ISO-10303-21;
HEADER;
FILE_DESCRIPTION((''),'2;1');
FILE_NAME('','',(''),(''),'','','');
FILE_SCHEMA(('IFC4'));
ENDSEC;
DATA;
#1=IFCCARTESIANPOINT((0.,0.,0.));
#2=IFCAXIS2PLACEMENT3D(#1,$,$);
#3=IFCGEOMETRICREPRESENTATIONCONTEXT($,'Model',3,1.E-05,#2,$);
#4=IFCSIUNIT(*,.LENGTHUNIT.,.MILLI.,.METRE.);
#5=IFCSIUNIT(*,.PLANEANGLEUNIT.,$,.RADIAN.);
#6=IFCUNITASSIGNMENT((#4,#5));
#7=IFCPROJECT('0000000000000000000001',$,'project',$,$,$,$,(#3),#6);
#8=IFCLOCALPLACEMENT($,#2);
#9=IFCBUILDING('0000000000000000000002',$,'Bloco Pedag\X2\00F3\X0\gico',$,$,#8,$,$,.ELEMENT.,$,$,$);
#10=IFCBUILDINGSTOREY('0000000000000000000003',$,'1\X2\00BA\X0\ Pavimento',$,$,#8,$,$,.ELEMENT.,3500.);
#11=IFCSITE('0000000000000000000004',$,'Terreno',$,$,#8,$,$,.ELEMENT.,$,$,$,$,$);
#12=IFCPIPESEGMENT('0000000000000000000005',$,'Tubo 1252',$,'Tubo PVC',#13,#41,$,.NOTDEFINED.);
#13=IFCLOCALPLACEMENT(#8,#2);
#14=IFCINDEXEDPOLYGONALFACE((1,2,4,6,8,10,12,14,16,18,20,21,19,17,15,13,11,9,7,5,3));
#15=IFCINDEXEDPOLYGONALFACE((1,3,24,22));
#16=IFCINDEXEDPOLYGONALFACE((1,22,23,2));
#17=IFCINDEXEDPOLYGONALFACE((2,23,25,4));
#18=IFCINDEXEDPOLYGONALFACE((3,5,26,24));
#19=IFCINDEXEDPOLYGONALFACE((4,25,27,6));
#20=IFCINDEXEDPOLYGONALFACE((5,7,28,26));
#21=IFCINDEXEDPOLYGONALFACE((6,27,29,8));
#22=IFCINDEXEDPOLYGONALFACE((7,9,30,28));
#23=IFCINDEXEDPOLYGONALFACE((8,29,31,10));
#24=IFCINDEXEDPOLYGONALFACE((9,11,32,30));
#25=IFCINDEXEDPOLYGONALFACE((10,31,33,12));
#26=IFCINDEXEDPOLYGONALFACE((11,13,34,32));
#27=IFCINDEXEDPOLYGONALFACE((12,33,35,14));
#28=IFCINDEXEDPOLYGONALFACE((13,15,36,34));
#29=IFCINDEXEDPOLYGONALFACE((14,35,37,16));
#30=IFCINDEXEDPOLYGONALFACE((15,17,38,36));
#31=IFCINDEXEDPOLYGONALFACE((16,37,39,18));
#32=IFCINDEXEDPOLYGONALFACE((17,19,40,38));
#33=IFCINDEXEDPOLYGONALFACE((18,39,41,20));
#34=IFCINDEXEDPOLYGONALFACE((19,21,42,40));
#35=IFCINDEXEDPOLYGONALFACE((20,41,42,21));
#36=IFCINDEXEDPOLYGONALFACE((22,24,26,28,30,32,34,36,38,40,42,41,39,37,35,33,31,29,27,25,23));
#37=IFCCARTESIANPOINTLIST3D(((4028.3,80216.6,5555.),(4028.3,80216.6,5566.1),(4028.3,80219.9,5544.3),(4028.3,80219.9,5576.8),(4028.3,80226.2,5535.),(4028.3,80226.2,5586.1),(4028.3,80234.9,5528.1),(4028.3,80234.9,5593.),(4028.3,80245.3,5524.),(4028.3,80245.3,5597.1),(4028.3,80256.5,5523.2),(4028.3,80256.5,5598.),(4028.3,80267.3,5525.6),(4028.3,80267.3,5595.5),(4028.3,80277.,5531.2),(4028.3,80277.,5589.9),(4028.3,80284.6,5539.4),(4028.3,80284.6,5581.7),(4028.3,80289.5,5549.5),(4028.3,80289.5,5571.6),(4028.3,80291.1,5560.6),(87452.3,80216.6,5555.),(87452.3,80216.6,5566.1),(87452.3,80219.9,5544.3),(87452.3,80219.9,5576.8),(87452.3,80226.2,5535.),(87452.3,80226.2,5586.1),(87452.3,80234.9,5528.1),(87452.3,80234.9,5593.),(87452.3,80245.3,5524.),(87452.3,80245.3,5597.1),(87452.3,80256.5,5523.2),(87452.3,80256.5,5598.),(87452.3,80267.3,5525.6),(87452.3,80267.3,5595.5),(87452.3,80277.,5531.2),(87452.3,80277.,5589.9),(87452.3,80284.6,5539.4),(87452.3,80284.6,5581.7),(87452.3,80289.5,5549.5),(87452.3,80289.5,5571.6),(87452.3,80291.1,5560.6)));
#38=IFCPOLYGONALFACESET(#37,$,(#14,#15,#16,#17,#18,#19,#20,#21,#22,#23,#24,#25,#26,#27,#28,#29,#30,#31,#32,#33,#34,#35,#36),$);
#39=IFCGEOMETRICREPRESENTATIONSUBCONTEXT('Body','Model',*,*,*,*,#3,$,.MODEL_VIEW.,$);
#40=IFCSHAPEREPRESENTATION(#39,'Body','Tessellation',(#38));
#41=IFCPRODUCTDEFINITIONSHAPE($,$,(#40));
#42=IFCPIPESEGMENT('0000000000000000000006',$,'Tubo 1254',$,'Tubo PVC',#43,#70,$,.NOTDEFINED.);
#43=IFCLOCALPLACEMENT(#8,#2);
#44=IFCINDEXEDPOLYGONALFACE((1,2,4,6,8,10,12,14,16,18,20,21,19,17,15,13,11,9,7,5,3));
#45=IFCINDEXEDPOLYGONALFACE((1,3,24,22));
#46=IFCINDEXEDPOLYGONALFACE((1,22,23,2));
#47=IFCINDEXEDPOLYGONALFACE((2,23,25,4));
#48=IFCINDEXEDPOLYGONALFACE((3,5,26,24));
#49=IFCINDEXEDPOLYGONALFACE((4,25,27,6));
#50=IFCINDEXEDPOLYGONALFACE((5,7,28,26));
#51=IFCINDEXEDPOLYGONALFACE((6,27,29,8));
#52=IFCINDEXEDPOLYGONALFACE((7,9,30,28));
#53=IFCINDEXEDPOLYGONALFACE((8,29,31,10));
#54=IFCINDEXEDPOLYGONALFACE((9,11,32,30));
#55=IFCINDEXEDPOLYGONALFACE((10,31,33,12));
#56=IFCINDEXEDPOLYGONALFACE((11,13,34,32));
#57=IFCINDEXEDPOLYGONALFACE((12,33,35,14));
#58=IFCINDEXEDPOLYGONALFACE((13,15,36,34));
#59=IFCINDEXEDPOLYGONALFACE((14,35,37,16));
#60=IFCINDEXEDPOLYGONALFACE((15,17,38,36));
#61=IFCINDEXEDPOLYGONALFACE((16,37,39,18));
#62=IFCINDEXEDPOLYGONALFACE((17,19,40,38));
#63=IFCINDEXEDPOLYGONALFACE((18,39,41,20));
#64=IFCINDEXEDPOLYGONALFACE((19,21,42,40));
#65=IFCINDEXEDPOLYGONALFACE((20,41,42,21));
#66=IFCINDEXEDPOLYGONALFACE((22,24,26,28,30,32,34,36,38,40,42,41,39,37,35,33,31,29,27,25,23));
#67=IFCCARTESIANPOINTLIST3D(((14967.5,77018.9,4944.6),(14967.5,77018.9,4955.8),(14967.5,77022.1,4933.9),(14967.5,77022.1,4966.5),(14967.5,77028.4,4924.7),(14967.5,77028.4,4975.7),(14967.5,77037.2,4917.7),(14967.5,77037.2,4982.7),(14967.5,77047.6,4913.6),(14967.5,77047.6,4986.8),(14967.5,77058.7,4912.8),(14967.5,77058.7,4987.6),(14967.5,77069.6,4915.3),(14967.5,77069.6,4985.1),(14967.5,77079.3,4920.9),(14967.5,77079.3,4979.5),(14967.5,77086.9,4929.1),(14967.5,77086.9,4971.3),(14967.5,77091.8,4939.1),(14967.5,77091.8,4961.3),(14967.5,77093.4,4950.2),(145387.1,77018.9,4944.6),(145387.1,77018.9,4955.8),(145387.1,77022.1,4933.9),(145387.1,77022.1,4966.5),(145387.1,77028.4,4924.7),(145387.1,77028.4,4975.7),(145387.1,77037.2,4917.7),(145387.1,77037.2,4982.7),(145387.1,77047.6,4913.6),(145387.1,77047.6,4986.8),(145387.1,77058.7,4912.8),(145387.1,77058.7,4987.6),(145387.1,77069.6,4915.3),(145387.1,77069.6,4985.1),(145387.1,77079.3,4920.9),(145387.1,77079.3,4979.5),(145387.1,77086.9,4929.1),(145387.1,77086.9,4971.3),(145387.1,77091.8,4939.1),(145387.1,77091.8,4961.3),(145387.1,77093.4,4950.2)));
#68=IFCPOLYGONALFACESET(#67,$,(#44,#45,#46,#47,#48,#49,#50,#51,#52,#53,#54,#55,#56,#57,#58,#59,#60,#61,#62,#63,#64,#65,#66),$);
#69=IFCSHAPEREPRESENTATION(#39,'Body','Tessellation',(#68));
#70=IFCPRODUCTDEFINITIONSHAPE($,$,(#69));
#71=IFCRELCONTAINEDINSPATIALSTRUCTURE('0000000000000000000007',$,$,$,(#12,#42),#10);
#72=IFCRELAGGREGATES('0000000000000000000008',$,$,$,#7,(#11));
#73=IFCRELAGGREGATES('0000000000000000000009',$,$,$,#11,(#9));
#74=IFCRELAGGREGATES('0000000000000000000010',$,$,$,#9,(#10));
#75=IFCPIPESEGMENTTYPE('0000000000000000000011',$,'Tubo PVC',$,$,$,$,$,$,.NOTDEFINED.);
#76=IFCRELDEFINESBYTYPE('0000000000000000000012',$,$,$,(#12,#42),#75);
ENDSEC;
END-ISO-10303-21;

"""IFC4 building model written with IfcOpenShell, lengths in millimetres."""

from ifc_helpers import new_model, si_unit, frame, origin, origin_2d, place, context, subcontext, project, spatial, circle, extrude, type_object, element, save


model = new_model("IFC4")

# Units and contexts
model_context = context("Model", 3, precision=1e-05, world=origin())
body_context = subcontext(model_context, "Body", "Model", "MODEL_VIEW")
ifc_project = project(units=[si_unit("LENGTHUNIT", "METRE", prefix="MILLI"), si_unit("PLANEANGLEUNIT", "RADIAN")], contexts=[model_context])

# Site, building, storey
placement = place(None, origin())
site = spatial("IfcSite", under=ifc_project, at=placement, Name="Terreno", CompositionType="ELEMENT")
building = spatial("IfcBuilding", under=site, at=placement, Name="Bloco Pedagógico", CompositionType="ELEMENT")
storey = spatial("IfcBuildingStorey", under=building, at=placement, Name="1º Pavimento", CompositionType="ELEMENT", Elevation=3500.0)

# Pipe segments
pipe_segment_type = type_object("IfcPipeSegmentType", Name="Tubo PVC", PredefinedType="NOTDEFINED")
pipe_segment_1_placement = place(None, frame((4028.3, 80253.6, 5560.6), z_axis=(1.0, 0.0, 0.0), x_axis=(0.0, 1.0, 0.0)))
element("IfcPipeSegment", 1, at=pipe_segment_1_placement, inside=storey, type_object=pipe_segment_type, Name="Tubo 1252", ObjectType="Tubo PVC", PredefinedType="NOTDEFINED", context=body_context, shape_type="SweptSolid", body=[
    extrude(circle(Radius=37.5, at=origin_2d()), None, (0.0, 0.0, 1.0), 83424.1),
])
pipe_segment_2_placement = place(None, frame((14967.5, 77055.9, 4950.2), z_axis=(1.0, 0.0, 0.0), x_axis=(0.0, 1.0, 0.0)))
element("IfcPipeSegment", 2, at=pipe_segment_2_placement, inside=storey, type_object=pipe_segment_type, Name="Tubo 1254", ObjectType="Tubo PVC", PredefinedType="NOTDEFINED", context=body_context, shape_type="SweptSolid", body=[
    extrude(circle(Radius=37.5, at=origin_2d()), None, (0.0, 0.0, 1.0), 130419.6),
])

save(model, "model.ifc")
